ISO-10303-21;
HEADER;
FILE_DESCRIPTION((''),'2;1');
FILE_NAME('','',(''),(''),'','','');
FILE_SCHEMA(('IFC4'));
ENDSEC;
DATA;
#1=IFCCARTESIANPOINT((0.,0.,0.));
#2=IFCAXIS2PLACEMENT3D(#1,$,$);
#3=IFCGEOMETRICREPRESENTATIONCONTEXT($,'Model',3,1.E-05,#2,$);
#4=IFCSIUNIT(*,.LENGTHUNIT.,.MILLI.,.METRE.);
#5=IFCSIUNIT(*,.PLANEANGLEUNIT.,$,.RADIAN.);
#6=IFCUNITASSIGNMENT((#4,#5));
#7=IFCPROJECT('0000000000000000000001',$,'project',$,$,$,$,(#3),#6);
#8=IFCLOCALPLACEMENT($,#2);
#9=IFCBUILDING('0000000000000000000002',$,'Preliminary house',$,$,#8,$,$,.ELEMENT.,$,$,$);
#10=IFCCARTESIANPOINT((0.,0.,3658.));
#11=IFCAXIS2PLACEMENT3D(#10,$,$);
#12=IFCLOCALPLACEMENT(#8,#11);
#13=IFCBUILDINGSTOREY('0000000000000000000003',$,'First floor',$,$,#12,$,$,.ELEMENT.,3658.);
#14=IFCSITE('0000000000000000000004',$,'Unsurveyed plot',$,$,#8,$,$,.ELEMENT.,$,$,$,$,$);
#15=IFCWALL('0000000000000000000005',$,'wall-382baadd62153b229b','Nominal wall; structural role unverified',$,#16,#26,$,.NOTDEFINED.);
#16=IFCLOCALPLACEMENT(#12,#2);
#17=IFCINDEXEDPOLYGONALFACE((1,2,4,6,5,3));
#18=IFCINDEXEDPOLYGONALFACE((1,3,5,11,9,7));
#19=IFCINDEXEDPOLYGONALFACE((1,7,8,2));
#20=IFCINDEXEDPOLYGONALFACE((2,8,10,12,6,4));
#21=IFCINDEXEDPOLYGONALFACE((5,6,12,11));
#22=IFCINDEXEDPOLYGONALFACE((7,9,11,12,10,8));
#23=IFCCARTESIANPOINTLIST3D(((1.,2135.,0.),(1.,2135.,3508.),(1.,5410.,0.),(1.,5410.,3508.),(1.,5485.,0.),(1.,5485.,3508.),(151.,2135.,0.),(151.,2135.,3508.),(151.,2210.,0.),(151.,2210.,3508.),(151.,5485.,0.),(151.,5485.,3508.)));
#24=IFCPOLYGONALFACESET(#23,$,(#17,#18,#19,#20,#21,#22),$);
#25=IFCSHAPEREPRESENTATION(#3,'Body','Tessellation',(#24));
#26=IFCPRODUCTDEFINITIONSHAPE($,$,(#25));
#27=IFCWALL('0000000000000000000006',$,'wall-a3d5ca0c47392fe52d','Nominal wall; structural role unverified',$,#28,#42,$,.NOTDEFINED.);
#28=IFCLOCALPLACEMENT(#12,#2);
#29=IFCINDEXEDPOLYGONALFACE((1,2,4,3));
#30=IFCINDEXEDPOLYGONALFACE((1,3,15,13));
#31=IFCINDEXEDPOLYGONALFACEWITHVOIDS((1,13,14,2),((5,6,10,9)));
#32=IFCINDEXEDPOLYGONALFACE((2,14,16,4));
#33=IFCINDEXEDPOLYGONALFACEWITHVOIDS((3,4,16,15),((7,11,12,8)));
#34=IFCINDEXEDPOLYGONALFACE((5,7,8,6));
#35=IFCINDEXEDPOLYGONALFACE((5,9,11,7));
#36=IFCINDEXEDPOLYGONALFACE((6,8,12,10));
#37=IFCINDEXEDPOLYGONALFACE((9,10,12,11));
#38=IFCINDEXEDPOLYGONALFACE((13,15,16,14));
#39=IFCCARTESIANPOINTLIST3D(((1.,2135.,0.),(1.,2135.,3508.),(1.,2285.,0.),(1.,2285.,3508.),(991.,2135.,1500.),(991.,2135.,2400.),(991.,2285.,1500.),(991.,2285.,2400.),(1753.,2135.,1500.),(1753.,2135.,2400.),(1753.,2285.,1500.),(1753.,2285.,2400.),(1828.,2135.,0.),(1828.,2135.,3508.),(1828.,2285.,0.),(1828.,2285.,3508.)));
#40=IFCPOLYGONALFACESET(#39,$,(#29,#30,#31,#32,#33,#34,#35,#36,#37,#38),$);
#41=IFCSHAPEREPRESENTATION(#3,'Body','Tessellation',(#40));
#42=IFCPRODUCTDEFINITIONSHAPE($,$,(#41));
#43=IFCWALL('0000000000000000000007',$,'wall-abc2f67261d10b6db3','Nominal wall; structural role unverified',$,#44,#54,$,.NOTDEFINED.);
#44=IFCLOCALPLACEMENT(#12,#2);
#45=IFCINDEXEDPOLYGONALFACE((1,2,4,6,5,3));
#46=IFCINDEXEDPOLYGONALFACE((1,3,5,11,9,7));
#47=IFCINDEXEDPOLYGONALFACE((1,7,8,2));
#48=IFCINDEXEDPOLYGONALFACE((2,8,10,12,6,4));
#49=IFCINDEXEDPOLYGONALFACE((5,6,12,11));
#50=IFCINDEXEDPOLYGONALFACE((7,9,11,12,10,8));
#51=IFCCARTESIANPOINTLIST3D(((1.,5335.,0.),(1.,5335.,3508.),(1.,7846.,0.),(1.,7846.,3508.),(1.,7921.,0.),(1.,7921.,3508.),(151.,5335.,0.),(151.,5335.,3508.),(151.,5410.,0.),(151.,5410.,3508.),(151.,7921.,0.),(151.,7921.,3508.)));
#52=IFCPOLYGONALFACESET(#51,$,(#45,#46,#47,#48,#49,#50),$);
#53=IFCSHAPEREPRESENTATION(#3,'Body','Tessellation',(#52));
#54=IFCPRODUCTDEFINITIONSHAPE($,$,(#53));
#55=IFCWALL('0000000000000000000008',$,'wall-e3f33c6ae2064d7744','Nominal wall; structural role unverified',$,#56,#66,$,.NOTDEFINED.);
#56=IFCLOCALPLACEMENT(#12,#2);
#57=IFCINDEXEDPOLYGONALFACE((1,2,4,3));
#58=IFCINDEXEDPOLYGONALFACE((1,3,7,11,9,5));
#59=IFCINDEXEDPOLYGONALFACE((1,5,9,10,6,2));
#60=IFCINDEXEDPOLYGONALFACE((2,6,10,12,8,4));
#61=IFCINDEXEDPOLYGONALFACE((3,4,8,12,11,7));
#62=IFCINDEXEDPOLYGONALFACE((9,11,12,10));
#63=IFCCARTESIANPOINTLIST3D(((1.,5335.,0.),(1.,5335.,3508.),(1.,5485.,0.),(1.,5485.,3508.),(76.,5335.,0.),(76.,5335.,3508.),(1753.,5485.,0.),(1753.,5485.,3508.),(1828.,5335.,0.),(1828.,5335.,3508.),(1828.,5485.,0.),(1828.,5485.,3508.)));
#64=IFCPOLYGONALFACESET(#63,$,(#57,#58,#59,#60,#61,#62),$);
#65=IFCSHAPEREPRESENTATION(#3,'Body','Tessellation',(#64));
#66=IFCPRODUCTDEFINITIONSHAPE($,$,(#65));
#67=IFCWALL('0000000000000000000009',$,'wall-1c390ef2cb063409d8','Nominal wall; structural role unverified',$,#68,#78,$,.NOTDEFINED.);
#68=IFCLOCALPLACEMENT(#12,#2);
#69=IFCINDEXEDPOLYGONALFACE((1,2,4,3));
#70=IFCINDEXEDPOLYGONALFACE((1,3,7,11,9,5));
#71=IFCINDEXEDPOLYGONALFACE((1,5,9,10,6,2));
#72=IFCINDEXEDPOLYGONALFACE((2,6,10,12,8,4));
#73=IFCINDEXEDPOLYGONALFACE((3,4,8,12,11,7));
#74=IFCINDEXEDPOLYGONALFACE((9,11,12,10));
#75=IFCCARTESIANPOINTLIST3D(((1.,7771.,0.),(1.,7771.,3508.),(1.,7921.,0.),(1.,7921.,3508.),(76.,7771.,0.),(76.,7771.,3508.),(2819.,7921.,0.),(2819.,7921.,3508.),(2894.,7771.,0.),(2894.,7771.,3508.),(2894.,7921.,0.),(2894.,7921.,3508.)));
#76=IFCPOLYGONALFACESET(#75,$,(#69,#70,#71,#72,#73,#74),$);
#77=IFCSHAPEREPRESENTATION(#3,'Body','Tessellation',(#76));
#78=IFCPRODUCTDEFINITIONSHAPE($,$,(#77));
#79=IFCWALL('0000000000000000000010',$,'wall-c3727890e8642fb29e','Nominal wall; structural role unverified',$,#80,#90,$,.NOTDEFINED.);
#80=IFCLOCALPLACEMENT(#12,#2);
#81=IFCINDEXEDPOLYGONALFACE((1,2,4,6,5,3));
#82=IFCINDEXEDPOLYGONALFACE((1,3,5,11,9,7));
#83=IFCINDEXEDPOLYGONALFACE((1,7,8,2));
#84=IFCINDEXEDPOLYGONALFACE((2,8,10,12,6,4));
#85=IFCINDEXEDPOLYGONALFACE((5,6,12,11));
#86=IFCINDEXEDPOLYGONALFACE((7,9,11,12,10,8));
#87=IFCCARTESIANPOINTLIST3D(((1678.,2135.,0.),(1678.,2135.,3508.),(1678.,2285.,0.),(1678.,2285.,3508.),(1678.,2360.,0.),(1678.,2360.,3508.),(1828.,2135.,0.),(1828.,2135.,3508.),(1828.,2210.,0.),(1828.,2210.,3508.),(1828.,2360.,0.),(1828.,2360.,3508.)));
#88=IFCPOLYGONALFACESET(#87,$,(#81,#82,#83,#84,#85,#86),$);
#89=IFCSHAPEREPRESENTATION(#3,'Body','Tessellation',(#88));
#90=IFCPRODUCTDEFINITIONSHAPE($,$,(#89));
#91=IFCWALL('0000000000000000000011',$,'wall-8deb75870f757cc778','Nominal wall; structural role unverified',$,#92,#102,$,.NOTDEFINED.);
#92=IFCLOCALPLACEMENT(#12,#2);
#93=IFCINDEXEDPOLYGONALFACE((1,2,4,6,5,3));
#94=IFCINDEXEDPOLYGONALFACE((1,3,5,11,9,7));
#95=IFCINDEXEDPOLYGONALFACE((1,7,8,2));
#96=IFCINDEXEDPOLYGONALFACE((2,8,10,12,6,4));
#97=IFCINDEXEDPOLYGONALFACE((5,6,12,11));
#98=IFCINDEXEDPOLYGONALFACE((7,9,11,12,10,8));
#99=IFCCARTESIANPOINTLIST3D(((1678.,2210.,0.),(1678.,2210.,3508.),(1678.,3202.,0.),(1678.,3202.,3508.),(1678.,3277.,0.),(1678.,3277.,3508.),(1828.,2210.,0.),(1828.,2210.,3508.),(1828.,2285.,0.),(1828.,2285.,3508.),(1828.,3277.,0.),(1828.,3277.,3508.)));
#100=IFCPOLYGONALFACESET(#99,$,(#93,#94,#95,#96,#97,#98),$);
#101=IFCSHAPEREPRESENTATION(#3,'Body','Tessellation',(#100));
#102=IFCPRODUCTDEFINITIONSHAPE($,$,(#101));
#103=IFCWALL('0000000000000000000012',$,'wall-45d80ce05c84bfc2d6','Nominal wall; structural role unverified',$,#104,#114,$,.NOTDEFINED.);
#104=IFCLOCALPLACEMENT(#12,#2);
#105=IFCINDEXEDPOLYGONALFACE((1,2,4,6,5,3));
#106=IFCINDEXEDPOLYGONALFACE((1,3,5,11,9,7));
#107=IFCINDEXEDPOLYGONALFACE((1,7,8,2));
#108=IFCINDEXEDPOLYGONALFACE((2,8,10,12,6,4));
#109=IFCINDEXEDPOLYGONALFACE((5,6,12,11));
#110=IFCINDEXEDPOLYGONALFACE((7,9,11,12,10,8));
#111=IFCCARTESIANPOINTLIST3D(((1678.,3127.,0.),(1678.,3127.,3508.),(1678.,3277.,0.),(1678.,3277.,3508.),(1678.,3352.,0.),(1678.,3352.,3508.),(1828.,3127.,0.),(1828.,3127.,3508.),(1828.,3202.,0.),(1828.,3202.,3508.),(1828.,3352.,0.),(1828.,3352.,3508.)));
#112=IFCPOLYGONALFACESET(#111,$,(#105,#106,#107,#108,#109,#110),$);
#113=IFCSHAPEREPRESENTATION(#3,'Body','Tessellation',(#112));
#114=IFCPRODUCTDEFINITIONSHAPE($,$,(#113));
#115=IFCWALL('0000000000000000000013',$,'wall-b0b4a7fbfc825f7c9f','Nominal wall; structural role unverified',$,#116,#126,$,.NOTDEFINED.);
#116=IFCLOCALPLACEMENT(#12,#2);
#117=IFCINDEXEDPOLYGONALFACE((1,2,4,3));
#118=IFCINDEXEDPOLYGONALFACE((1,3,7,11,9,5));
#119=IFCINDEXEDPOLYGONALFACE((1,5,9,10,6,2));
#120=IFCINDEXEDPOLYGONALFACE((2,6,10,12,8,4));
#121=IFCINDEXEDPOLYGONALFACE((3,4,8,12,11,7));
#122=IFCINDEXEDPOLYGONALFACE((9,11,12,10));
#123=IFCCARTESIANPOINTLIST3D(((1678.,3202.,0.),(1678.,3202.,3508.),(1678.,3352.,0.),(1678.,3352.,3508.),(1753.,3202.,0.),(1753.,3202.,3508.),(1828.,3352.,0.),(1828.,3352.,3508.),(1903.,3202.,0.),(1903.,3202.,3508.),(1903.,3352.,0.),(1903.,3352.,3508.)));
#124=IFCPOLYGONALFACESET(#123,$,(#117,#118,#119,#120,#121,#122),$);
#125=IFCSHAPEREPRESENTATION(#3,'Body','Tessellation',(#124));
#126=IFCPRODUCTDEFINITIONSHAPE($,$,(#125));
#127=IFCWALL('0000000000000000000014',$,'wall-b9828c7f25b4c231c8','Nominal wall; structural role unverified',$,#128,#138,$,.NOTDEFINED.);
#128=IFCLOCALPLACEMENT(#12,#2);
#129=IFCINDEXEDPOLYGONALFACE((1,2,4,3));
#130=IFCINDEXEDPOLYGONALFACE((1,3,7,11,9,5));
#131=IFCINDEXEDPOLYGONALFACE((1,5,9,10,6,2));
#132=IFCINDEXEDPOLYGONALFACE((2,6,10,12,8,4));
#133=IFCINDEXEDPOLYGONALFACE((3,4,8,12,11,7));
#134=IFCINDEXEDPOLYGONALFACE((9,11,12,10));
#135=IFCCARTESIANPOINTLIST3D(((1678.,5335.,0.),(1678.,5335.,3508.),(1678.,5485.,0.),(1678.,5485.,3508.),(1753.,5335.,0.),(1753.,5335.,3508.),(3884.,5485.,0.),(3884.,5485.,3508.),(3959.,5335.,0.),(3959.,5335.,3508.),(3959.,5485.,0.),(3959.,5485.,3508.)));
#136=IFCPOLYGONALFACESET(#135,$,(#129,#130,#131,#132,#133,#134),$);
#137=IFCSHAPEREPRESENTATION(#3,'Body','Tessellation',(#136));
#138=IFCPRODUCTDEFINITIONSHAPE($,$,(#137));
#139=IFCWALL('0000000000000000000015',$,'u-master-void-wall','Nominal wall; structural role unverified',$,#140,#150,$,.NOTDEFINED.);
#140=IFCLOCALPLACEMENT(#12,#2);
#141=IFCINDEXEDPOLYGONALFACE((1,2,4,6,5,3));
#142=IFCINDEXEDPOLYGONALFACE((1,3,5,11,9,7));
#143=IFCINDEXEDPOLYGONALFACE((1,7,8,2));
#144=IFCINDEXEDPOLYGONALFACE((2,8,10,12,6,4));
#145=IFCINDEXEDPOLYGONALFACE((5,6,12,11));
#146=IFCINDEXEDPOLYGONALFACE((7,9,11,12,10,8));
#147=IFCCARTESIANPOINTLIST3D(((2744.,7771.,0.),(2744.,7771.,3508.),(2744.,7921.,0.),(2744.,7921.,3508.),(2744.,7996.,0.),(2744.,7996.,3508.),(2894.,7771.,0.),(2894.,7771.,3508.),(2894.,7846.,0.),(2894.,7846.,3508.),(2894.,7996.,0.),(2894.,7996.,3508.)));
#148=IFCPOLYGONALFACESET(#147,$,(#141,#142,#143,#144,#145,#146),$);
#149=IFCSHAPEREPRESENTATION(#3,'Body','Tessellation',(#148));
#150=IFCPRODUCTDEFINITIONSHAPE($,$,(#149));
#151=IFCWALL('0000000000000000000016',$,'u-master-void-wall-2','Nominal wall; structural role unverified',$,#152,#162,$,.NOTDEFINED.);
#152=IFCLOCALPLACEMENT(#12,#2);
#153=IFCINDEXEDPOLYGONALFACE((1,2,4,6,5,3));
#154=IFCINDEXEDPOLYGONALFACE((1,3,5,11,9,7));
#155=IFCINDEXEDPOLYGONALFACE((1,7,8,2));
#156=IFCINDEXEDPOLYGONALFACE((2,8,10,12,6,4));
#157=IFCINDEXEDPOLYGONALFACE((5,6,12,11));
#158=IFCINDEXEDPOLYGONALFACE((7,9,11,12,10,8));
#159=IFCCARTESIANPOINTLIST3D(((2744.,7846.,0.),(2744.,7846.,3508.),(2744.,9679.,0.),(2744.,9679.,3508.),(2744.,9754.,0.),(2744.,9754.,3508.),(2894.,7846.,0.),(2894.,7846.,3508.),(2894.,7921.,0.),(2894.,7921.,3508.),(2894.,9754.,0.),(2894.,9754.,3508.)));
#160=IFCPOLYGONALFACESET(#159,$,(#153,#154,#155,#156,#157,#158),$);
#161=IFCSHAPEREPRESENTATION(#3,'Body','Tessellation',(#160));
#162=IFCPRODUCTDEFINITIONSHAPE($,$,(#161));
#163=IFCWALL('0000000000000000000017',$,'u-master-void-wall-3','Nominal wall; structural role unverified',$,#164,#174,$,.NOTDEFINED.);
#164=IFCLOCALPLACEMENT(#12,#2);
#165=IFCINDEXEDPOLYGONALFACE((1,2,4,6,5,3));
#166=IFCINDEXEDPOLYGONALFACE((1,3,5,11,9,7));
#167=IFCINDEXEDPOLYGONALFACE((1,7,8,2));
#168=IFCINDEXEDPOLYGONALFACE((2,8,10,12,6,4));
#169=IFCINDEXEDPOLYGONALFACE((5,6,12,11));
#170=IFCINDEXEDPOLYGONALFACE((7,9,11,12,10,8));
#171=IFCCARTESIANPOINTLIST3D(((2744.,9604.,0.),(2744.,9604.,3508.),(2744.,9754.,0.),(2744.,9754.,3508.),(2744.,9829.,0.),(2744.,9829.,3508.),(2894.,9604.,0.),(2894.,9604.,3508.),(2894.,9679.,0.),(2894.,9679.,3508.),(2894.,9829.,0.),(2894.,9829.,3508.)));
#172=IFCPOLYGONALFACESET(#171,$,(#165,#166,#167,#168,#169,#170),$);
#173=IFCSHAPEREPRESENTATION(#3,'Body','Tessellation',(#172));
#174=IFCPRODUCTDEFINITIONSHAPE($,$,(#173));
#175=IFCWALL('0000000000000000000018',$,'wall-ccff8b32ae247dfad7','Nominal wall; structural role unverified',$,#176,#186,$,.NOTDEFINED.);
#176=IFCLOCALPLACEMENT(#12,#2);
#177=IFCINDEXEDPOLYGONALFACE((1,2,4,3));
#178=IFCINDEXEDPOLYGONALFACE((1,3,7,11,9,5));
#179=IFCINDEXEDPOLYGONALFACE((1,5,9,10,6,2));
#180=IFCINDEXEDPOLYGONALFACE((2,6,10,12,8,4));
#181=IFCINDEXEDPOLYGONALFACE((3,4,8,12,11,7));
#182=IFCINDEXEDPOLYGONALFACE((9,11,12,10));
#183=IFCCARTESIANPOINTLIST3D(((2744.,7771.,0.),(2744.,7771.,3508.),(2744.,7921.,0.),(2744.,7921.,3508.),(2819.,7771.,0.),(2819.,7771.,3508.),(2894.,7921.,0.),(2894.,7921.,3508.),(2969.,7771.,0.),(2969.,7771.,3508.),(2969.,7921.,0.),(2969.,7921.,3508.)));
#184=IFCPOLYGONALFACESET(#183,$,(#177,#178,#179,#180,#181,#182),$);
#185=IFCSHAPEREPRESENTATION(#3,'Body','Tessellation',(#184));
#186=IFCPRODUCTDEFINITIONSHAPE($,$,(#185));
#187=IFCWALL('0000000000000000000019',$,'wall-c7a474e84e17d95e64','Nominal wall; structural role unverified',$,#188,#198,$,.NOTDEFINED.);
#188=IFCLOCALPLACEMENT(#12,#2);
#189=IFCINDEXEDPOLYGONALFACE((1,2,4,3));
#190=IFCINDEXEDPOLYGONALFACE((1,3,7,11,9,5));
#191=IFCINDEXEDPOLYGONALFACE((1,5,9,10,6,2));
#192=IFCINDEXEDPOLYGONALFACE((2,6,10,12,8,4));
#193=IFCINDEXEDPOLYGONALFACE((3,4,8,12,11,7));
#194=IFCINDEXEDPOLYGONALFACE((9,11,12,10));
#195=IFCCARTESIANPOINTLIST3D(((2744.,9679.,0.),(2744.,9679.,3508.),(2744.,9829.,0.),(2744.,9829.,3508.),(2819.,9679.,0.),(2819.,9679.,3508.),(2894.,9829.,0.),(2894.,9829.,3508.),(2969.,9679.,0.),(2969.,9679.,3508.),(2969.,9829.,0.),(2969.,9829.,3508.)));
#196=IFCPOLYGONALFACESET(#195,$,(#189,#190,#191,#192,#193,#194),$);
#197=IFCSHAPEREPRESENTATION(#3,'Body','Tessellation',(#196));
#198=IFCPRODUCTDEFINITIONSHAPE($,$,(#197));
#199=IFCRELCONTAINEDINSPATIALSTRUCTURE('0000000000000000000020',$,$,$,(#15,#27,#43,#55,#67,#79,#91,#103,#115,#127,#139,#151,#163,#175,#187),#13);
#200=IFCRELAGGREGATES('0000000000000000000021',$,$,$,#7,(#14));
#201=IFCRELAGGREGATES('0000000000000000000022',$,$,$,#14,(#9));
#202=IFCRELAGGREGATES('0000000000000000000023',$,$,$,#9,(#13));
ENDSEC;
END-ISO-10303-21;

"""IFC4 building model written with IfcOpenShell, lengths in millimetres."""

from ifc_helpers import new_model, si_unit, frame, origin, place, context, project, spatial, polyline, outline, extrude, element, save


model = new_model("IFC4")

# Units and contexts
model_context = context("Model", 3, precision=1e-05, world=origin())
ifc_project = project(units=[si_unit("LENGTHUNIT", "METRE", prefix="MILLI"), si_unit("PLANEANGLEUNIT", "RADIAN")], contexts=[model_context])

# Site, building, storey
placement_1 = place(None, origin())
site = spatial("IfcSite", under=ifc_project, at=placement_1, Name="Unsurveyed plot", CompositionType="ELEMENT")
building = spatial("IfcBuilding", under=site, at=placement_1, Name="Preliminary house", CompositionType="ELEMENT")
placement_2 = place(placement_1, frame((0.0, 0.0, 3658.0)))
storey = spatial("IfcBuildingStorey", under=building, at=placement_2, Name="First floor", CompositionType="ELEMENT", Elevation=3658.0)

# Wall
element("IfcWall", 1, at=placement_2, inside=storey, Name="wall-382baadd62153b229b", Description="Nominal wall; structural role unverified", PredefinedType="NOTDEFINED", context=model_context, shape_type="SweptSolid", body=[
    extrude(outline(polyline([(1.0, 5410.0), (1.0, 5485.0), (151.0, 5485.0), (151.0, 2210.0), (151.0, 2135.0), (1.0, 2135.0), (1.0, 5410.0)])), origin(), (0.0, 0.0, 1.0), 3508.0),
])

# Wall, opening
wall_1 = element("IfcWall", 2, at=placement_2, inside=storey, Name="wall-a3d5ca0c47392fe52d", Description="Nominal wall; structural role unverified", PredefinedType="NOTDEFINED", context=model_context, shape_type="SweptSolid", body=[
    extrude(outline(polyline([(1753.0, 2285.0), (1828.0, 2285.0), (1828.0, 2135.0), (76.0, 2135.0), (1.0, 2135.0), (1.0, 2285.0), (1753.0, 2285.0)])), origin(), (0.0, 0.0, 1.0), 3508.0),
])
element("IfcOpeningElement", 3, at=placement_2, cuts=wall_1, PredefinedType="OPENING", context=model_context, shape_type="SweptSolid", body=[
    extrude(outline(polyline([(991.0, 1760.0), (1753.0, 1760.0), (1753.0, 2660.0), (991.0, 2660.0), (991.0, 1760.0)])), frame((0.0, 0.0, 1500.0)), (0.0, 0.0, 1.0), 900.0),
])

# Walls
element("IfcWall", 4, at=placement_2, inside=storey, Name="wall-abc2f67261d10b6db3", Description="Nominal wall; structural role unverified", PredefinedType="NOTDEFINED", context=model_context, shape_type="SweptSolid", body=[
    extrude(outline(polyline([(1.0, 7846.0), (1.0, 7921.0), (151.0, 7921.0), (151.0, 5410.0), (151.0, 5335.0), (1.0, 5335.0), (1.0, 7846.0)])), origin(), (0.0, 0.0, 1.0), 3508.0),
])
element("IfcWall", 5, at=placement_2, inside=storey, Name="wall-e3f33c6ae2064d7744", Description="Nominal wall; structural role unverified", PredefinedType="NOTDEFINED", context=model_context, shape_type="SweptSolid", body=[
    extrude(outline(polyline([(1753.0, 5485.0), (1828.0, 5485.0), (1828.0, 5335.0), (76.0, 5335.0), (1.0, 5335.0), (1.0, 5485.0), (1753.0, 5485.0)])), origin(), (0.0, 0.0, 1.0), 3508.0),
])

# Wall
element("IfcWall", 6, at=placement_2, inside=storey, Name="wall-1c390ef2cb063409d8", Description="Nominal wall; structural role unverified", PredefinedType="NOTDEFINED", context=model_context, shape_type="SweptSolid", body=[
    extrude(outline(polyline([(2819.0, 7921.0), (2894.0, 7921.0), (2894.0, 7771.0), (76.0, 7771.0), (1.0, 7771.0), (1.0, 7921.0), (2819.0, 7921.0)])), origin(), (0.0, 0.0, 1.0), 3508.0),
])

# Walls
element("IfcWall", 7, at=placement_2, inside=storey, Name="wall-c3727890e8642fb29e", Description="Nominal wall; structural role unverified", PredefinedType="NOTDEFINED", context=model_context, shape_type="SweptSolid", body=[
    extrude(outline(polyline([(1678.0, 2285.0), (1678.0, 2360.0), (1828.0, 2360.0), (1828.0, 2210.0), (1828.0, 2135.0), (1678.0, 2135.0), (1678.0, 2285.0)])), origin(), (0.0, 0.0, 1.0), 3508.0),
])
element("IfcWall", 8, at=placement_2, inside=storey, Name="wall-8deb75870f757cc778", Description="Nominal wall; structural role unverified", PredefinedType="NOTDEFINED", context=model_context, shape_type="SweptSolid", body=[
    extrude(outline(polyline([(1678.0, 3202.0), (1678.0, 3277.0), (1828.0, 3277.0), (1828.0, 2285.0), (1828.0, 2210.0), (1678.0, 2210.0), (1678.0, 3202.0)])), origin(), (0.0, 0.0, 1.0), 3508.0),
])
element("IfcWall", 9, at=placement_2, inside=storey, Name="wall-45d80ce05c84bfc2d6", Description="Nominal wall; structural role unverified", PredefinedType="NOTDEFINED", context=model_context, shape_type="SweptSolid", body=[
    extrude(outline(polyline([(1678.0, 3277.0), (1678.0, 3352.0), (1828.0, 3352.0), (1828.0, 3202.0), (1828.0, 3127.0), (1678.0, 3127.0), (1678.0, 3277.0)])), origin(), (0.0, 0.0, 1.0), 3508.0),
])

# Wall
element("IfcWall", 10, at=placement_2, inside=storey, Name="wall-b0b4a7fbfc825f7c9f", Description="Nominal wall; structural role unverified", PredefinedType="NOTDEFINED", context=model_context, shape_type="SweptSolid", body=[
    extrude(outline(polyline([(1828.0, 3352.0), (1903.0, 3352.0), (1903.0, 3202.0), (1753.0, 3202.0), (1678.0, 3202.0), (1678.0, 3352.0), (1828.0, 3352.0)])), origin(), (0.0, 0.0, 1.0), 3508.0),
])

# Walls
element("IfcWall", 11, at=placement_2, inside=storey, Name="wall-b9828c7f25b4c231c8", Description="Nominal wall; structural role unverified", PredefinedType="NOTDEFINED", context=model_context, shape_type="SweptSolid", body=[
    extrude(outline(polyline([(3884.0, 5485.0), (3959.0, 5485.0), (3959.0, 5335.0), (1753.0, 5335.0), (1678.0, 5335.0), (1678.0, 5485.0), (3884.0, 5485.0)])), origin(), (0.0, 0.0, 1.0), 3508.0),
])
element("IfcWall", 12, at=placement_2, inside=storey, Name="u-master-void-wall", Description="Nominal wall; structural role unverified", PredefinedType="NOTDEFINED", context=model_context, shape_type="SweptSolid", body=[
    extrude(outline(polyline([(2744.0, 7921.0), (2744.0, 7996.0), (2894.0, 7996.0), (2894.0, 7846.0), (2894.0, 7771.0), (2744.0, 7771.0), (2744.0, 7921.0)])), origin(), (0.0, 0.0, 1.0), 3508.0),
])
element("IfcWall", 13, at=placement_2, inside=storey, Name="u-master-void-wall-2", Description="Nominal wall; structural role unverified", PredefinedType="NOTDEFINED", context=model_context, shape_type="SweptSolid", body=[
    extrude(outline(polyline([(2744.0, 9679.0), (2744.0, 9754.0), (2894.0, 9754.0), (2894.0, 7921.0), (2894.0, 7846.0), (2744.0, 7846.0), (2744.0, 9679.0)])), origin(), (0.0, 0.0, 1.0), 3508.0),
])
element("IfcWall", 14, at=placement_2, inside=storey, Name="u-master-void-wall-3", Description="Nominal wall; structural role unverified", PredefinedType="NOTDEFINED", context=model_context, shape_type="SweptSolid", body=[
    extrude(outline(polyline([(2744.0, 9754.0), (2744.0, 9829.0), (2894.0, 9829.0), (2894.0, 9679.0), (2894.0, 9604.0), (2744.0, 9604.0), (2744.0, 9754.0)])), origin(), (0.0, 0.0, 1.0), 3508.0),
])
element("IfcWall", 15, at=placement_2, inside=storey, Name="wall-ccff8b32ae247dfad7", Description="Nominal wall; structural role unverified", PredefinedType="NOTDEFINED", context=model_context, shape_type="SweptSolid", body=[
    extrude(outline(polyline([(2894.0, 7921.0), (2969.0, 7921.0), (2969.0, 7771.0), (2819.0, 7771.0), (2744.0, 7771.0), (2744.0, 7921.0), (2894.0, 7921.0)])), origin(), (0.0, 0.0, 1.0), 3508.0),
])
element("IfcWall", 16, at=placement_2, inside=storey, Name="wall-c7a474e84e17d95e64", Description="Nominal wall; structural role unverified", PredefinedType="NOTDEFINED", context=model_context, shape_type="SweptSolid", body=[
    extrude(outline(polyline([(2894.0, 9829.0), (2969.0, 9829.0), (2969.0, 9679.0), (2819.0, 9679.0), (2744.0, 9679.0), (2744.0, 9829.0), (2894.0, 9829.0)])), origin(), (0.0, 0.0, 1.0), 3508.0),
])

save(model, "model.ifc")
